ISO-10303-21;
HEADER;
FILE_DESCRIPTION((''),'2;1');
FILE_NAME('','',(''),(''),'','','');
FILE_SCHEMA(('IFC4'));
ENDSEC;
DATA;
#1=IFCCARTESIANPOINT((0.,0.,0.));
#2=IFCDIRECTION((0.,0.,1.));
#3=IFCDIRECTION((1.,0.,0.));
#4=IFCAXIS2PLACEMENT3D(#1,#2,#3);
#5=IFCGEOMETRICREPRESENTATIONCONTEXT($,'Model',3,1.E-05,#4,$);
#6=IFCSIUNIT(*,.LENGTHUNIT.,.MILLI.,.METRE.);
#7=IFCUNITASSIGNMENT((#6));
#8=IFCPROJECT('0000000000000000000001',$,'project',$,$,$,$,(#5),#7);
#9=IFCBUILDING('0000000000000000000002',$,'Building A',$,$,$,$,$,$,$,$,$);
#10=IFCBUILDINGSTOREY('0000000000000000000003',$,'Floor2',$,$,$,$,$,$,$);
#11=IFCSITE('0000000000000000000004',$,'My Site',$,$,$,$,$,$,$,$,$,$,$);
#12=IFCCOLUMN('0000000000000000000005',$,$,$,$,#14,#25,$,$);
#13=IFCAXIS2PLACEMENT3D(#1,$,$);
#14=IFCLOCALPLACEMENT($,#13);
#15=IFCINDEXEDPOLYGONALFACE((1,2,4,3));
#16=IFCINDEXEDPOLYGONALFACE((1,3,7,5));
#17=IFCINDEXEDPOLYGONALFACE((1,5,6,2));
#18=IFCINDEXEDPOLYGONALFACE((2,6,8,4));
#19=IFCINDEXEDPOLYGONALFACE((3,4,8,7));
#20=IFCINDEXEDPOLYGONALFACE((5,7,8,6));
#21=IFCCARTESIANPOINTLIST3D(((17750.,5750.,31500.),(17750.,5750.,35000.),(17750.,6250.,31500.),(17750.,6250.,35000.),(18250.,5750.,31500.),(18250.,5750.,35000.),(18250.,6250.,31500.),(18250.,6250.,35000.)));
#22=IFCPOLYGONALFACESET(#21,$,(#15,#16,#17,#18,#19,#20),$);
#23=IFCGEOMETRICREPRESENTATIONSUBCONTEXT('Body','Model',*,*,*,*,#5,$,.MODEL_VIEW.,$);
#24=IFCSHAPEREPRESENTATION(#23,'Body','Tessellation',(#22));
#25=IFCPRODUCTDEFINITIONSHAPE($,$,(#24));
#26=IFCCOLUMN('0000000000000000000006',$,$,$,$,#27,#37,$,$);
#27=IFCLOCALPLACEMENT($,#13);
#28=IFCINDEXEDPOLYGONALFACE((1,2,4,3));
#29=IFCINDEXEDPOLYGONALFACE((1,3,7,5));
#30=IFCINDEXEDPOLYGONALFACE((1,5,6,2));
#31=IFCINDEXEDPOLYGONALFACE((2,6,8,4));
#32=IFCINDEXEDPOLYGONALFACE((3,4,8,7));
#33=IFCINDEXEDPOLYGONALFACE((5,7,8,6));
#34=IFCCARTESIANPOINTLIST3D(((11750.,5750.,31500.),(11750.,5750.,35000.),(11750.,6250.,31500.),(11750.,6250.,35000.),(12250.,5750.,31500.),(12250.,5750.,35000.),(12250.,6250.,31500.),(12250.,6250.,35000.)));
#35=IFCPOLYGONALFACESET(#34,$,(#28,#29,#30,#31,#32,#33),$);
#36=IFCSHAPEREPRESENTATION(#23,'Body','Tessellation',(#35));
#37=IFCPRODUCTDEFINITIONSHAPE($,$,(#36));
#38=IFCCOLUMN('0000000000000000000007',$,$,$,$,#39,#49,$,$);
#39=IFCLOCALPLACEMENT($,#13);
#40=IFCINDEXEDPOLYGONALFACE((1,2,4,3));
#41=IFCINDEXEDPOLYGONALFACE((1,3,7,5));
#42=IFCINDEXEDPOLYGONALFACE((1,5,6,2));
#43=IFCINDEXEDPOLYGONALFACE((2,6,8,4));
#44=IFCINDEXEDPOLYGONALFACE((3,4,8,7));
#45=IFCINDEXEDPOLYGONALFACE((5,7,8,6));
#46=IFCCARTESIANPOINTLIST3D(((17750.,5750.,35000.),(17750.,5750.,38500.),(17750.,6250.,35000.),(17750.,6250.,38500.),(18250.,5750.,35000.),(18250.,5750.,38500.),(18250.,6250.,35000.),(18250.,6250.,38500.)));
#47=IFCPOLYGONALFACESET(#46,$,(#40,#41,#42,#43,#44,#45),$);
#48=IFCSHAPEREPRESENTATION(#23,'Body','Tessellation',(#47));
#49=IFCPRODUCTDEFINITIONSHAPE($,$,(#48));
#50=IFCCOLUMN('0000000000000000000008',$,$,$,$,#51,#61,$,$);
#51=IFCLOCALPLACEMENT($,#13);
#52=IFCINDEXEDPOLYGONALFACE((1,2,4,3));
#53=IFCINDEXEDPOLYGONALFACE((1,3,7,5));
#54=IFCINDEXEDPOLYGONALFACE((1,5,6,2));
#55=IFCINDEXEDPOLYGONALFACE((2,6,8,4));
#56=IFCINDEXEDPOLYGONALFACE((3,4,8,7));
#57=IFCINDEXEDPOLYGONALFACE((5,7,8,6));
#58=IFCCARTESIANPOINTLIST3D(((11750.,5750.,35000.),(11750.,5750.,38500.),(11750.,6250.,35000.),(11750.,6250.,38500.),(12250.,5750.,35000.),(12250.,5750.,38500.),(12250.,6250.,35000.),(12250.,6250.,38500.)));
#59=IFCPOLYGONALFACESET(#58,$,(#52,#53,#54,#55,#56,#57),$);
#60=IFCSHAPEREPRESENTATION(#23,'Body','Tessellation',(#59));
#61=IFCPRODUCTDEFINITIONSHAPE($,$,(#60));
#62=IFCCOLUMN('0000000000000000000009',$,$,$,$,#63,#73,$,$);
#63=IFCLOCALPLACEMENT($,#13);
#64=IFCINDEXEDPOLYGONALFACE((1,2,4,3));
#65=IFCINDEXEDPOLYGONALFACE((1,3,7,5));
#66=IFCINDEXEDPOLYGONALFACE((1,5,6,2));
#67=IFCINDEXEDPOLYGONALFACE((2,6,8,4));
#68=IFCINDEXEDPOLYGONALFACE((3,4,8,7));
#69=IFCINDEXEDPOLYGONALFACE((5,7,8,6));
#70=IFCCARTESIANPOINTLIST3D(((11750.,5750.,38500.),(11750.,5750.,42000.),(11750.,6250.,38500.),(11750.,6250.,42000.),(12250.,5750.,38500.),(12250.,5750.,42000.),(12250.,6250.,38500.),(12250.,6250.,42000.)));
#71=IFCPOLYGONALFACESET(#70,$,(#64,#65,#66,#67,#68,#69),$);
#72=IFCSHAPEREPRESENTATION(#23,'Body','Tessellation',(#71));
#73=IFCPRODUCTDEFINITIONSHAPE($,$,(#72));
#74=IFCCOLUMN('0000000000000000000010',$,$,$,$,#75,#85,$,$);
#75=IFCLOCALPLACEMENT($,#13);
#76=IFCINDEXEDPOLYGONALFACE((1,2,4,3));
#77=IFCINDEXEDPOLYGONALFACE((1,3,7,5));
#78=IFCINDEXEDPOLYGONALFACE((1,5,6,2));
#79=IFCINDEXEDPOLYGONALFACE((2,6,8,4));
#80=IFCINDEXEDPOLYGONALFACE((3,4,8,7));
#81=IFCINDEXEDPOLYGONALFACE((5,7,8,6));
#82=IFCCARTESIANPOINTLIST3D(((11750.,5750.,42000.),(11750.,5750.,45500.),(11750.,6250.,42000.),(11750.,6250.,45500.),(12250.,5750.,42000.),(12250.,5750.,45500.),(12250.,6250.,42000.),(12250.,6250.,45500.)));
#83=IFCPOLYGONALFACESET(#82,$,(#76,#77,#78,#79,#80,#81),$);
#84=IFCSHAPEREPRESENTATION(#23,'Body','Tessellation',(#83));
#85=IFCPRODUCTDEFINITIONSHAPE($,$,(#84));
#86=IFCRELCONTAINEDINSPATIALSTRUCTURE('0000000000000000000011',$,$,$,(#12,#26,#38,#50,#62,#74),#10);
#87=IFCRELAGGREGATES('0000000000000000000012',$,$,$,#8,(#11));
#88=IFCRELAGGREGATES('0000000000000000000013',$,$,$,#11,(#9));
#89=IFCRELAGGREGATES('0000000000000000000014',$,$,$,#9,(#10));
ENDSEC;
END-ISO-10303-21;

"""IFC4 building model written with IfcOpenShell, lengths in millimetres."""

from ifc_helpers import new_model, si_unit, frame, origin_with_axes, place, context, subcontext, project, spatial, line, indexed_curve, outline, extrude, element, save


model = new_model("IFC4")

# Units and contexts
model_context = context("Model", 3, precision=1e-05, world=origin_with_axes())
body_context = subcontext(model_context, "Body", "Model", "MODEL_VIEW")
ifc_project = project(units=[si_unit("LENGTHUNIT", "METRE", prefix="MILLI")], contexts=[model_context])

# Site, building, storey
site = spatial("IfcSite", under=ifc_project, Name="My Site")
building = spatial("IfcBuilding", under=site, Name="Building A")
storey = spatial("IfcBuildingStorey", under=building, Name="Floor2")

# Columns
for number, where, z_axis, x_axis in (
    (1, (18000.0, 6000.0, 31500.0), (0.0, 0.0, 1.0), (1.0, 0.0, 0.0)),
    (2, (12000.0, 6000.0, 31500.0), (0.0, 0.0, 1.0), (1.0, 0.0, 0.0)),
    (3, (18000.0, 6000.0, 35000.0), (0.0, 0.0, 1.0), (1.0, 0.0, 0.0)),
    (4, (12000.0, 6000.0, 35000.0), (0.0, 0.0, 1.0), (1.0, 0.0, 0.0)),
    (5, (12000.0, 6000.0, 38500.0), (0.0, 0.0, 1.0), (1.0, 0.0, 0.0)),
    (6, (12000.0, 6000.0, 42000.0), (0.0, 0.0, 1.0), (1.0, 0.0, 0.0)),
):
    element("IfcColumn", number, at=place(None, frame(where, z_axis=z_axis, x_axis=x_axis)), inside=storey, context=body_context, shape_type="SweptSolid", body=[
        extrude(outline(indexed_curve([(-250.0, -250.0), (250.0, -250.0), (250.0, 250.0), (-250.0, 250.0)], segments=[line(1, 2, 3, 4, 1)])), origin_with_axes(), (0.0, 0.0, 1.0), 3500.0),
    ])

save(model, "model.ifc")
